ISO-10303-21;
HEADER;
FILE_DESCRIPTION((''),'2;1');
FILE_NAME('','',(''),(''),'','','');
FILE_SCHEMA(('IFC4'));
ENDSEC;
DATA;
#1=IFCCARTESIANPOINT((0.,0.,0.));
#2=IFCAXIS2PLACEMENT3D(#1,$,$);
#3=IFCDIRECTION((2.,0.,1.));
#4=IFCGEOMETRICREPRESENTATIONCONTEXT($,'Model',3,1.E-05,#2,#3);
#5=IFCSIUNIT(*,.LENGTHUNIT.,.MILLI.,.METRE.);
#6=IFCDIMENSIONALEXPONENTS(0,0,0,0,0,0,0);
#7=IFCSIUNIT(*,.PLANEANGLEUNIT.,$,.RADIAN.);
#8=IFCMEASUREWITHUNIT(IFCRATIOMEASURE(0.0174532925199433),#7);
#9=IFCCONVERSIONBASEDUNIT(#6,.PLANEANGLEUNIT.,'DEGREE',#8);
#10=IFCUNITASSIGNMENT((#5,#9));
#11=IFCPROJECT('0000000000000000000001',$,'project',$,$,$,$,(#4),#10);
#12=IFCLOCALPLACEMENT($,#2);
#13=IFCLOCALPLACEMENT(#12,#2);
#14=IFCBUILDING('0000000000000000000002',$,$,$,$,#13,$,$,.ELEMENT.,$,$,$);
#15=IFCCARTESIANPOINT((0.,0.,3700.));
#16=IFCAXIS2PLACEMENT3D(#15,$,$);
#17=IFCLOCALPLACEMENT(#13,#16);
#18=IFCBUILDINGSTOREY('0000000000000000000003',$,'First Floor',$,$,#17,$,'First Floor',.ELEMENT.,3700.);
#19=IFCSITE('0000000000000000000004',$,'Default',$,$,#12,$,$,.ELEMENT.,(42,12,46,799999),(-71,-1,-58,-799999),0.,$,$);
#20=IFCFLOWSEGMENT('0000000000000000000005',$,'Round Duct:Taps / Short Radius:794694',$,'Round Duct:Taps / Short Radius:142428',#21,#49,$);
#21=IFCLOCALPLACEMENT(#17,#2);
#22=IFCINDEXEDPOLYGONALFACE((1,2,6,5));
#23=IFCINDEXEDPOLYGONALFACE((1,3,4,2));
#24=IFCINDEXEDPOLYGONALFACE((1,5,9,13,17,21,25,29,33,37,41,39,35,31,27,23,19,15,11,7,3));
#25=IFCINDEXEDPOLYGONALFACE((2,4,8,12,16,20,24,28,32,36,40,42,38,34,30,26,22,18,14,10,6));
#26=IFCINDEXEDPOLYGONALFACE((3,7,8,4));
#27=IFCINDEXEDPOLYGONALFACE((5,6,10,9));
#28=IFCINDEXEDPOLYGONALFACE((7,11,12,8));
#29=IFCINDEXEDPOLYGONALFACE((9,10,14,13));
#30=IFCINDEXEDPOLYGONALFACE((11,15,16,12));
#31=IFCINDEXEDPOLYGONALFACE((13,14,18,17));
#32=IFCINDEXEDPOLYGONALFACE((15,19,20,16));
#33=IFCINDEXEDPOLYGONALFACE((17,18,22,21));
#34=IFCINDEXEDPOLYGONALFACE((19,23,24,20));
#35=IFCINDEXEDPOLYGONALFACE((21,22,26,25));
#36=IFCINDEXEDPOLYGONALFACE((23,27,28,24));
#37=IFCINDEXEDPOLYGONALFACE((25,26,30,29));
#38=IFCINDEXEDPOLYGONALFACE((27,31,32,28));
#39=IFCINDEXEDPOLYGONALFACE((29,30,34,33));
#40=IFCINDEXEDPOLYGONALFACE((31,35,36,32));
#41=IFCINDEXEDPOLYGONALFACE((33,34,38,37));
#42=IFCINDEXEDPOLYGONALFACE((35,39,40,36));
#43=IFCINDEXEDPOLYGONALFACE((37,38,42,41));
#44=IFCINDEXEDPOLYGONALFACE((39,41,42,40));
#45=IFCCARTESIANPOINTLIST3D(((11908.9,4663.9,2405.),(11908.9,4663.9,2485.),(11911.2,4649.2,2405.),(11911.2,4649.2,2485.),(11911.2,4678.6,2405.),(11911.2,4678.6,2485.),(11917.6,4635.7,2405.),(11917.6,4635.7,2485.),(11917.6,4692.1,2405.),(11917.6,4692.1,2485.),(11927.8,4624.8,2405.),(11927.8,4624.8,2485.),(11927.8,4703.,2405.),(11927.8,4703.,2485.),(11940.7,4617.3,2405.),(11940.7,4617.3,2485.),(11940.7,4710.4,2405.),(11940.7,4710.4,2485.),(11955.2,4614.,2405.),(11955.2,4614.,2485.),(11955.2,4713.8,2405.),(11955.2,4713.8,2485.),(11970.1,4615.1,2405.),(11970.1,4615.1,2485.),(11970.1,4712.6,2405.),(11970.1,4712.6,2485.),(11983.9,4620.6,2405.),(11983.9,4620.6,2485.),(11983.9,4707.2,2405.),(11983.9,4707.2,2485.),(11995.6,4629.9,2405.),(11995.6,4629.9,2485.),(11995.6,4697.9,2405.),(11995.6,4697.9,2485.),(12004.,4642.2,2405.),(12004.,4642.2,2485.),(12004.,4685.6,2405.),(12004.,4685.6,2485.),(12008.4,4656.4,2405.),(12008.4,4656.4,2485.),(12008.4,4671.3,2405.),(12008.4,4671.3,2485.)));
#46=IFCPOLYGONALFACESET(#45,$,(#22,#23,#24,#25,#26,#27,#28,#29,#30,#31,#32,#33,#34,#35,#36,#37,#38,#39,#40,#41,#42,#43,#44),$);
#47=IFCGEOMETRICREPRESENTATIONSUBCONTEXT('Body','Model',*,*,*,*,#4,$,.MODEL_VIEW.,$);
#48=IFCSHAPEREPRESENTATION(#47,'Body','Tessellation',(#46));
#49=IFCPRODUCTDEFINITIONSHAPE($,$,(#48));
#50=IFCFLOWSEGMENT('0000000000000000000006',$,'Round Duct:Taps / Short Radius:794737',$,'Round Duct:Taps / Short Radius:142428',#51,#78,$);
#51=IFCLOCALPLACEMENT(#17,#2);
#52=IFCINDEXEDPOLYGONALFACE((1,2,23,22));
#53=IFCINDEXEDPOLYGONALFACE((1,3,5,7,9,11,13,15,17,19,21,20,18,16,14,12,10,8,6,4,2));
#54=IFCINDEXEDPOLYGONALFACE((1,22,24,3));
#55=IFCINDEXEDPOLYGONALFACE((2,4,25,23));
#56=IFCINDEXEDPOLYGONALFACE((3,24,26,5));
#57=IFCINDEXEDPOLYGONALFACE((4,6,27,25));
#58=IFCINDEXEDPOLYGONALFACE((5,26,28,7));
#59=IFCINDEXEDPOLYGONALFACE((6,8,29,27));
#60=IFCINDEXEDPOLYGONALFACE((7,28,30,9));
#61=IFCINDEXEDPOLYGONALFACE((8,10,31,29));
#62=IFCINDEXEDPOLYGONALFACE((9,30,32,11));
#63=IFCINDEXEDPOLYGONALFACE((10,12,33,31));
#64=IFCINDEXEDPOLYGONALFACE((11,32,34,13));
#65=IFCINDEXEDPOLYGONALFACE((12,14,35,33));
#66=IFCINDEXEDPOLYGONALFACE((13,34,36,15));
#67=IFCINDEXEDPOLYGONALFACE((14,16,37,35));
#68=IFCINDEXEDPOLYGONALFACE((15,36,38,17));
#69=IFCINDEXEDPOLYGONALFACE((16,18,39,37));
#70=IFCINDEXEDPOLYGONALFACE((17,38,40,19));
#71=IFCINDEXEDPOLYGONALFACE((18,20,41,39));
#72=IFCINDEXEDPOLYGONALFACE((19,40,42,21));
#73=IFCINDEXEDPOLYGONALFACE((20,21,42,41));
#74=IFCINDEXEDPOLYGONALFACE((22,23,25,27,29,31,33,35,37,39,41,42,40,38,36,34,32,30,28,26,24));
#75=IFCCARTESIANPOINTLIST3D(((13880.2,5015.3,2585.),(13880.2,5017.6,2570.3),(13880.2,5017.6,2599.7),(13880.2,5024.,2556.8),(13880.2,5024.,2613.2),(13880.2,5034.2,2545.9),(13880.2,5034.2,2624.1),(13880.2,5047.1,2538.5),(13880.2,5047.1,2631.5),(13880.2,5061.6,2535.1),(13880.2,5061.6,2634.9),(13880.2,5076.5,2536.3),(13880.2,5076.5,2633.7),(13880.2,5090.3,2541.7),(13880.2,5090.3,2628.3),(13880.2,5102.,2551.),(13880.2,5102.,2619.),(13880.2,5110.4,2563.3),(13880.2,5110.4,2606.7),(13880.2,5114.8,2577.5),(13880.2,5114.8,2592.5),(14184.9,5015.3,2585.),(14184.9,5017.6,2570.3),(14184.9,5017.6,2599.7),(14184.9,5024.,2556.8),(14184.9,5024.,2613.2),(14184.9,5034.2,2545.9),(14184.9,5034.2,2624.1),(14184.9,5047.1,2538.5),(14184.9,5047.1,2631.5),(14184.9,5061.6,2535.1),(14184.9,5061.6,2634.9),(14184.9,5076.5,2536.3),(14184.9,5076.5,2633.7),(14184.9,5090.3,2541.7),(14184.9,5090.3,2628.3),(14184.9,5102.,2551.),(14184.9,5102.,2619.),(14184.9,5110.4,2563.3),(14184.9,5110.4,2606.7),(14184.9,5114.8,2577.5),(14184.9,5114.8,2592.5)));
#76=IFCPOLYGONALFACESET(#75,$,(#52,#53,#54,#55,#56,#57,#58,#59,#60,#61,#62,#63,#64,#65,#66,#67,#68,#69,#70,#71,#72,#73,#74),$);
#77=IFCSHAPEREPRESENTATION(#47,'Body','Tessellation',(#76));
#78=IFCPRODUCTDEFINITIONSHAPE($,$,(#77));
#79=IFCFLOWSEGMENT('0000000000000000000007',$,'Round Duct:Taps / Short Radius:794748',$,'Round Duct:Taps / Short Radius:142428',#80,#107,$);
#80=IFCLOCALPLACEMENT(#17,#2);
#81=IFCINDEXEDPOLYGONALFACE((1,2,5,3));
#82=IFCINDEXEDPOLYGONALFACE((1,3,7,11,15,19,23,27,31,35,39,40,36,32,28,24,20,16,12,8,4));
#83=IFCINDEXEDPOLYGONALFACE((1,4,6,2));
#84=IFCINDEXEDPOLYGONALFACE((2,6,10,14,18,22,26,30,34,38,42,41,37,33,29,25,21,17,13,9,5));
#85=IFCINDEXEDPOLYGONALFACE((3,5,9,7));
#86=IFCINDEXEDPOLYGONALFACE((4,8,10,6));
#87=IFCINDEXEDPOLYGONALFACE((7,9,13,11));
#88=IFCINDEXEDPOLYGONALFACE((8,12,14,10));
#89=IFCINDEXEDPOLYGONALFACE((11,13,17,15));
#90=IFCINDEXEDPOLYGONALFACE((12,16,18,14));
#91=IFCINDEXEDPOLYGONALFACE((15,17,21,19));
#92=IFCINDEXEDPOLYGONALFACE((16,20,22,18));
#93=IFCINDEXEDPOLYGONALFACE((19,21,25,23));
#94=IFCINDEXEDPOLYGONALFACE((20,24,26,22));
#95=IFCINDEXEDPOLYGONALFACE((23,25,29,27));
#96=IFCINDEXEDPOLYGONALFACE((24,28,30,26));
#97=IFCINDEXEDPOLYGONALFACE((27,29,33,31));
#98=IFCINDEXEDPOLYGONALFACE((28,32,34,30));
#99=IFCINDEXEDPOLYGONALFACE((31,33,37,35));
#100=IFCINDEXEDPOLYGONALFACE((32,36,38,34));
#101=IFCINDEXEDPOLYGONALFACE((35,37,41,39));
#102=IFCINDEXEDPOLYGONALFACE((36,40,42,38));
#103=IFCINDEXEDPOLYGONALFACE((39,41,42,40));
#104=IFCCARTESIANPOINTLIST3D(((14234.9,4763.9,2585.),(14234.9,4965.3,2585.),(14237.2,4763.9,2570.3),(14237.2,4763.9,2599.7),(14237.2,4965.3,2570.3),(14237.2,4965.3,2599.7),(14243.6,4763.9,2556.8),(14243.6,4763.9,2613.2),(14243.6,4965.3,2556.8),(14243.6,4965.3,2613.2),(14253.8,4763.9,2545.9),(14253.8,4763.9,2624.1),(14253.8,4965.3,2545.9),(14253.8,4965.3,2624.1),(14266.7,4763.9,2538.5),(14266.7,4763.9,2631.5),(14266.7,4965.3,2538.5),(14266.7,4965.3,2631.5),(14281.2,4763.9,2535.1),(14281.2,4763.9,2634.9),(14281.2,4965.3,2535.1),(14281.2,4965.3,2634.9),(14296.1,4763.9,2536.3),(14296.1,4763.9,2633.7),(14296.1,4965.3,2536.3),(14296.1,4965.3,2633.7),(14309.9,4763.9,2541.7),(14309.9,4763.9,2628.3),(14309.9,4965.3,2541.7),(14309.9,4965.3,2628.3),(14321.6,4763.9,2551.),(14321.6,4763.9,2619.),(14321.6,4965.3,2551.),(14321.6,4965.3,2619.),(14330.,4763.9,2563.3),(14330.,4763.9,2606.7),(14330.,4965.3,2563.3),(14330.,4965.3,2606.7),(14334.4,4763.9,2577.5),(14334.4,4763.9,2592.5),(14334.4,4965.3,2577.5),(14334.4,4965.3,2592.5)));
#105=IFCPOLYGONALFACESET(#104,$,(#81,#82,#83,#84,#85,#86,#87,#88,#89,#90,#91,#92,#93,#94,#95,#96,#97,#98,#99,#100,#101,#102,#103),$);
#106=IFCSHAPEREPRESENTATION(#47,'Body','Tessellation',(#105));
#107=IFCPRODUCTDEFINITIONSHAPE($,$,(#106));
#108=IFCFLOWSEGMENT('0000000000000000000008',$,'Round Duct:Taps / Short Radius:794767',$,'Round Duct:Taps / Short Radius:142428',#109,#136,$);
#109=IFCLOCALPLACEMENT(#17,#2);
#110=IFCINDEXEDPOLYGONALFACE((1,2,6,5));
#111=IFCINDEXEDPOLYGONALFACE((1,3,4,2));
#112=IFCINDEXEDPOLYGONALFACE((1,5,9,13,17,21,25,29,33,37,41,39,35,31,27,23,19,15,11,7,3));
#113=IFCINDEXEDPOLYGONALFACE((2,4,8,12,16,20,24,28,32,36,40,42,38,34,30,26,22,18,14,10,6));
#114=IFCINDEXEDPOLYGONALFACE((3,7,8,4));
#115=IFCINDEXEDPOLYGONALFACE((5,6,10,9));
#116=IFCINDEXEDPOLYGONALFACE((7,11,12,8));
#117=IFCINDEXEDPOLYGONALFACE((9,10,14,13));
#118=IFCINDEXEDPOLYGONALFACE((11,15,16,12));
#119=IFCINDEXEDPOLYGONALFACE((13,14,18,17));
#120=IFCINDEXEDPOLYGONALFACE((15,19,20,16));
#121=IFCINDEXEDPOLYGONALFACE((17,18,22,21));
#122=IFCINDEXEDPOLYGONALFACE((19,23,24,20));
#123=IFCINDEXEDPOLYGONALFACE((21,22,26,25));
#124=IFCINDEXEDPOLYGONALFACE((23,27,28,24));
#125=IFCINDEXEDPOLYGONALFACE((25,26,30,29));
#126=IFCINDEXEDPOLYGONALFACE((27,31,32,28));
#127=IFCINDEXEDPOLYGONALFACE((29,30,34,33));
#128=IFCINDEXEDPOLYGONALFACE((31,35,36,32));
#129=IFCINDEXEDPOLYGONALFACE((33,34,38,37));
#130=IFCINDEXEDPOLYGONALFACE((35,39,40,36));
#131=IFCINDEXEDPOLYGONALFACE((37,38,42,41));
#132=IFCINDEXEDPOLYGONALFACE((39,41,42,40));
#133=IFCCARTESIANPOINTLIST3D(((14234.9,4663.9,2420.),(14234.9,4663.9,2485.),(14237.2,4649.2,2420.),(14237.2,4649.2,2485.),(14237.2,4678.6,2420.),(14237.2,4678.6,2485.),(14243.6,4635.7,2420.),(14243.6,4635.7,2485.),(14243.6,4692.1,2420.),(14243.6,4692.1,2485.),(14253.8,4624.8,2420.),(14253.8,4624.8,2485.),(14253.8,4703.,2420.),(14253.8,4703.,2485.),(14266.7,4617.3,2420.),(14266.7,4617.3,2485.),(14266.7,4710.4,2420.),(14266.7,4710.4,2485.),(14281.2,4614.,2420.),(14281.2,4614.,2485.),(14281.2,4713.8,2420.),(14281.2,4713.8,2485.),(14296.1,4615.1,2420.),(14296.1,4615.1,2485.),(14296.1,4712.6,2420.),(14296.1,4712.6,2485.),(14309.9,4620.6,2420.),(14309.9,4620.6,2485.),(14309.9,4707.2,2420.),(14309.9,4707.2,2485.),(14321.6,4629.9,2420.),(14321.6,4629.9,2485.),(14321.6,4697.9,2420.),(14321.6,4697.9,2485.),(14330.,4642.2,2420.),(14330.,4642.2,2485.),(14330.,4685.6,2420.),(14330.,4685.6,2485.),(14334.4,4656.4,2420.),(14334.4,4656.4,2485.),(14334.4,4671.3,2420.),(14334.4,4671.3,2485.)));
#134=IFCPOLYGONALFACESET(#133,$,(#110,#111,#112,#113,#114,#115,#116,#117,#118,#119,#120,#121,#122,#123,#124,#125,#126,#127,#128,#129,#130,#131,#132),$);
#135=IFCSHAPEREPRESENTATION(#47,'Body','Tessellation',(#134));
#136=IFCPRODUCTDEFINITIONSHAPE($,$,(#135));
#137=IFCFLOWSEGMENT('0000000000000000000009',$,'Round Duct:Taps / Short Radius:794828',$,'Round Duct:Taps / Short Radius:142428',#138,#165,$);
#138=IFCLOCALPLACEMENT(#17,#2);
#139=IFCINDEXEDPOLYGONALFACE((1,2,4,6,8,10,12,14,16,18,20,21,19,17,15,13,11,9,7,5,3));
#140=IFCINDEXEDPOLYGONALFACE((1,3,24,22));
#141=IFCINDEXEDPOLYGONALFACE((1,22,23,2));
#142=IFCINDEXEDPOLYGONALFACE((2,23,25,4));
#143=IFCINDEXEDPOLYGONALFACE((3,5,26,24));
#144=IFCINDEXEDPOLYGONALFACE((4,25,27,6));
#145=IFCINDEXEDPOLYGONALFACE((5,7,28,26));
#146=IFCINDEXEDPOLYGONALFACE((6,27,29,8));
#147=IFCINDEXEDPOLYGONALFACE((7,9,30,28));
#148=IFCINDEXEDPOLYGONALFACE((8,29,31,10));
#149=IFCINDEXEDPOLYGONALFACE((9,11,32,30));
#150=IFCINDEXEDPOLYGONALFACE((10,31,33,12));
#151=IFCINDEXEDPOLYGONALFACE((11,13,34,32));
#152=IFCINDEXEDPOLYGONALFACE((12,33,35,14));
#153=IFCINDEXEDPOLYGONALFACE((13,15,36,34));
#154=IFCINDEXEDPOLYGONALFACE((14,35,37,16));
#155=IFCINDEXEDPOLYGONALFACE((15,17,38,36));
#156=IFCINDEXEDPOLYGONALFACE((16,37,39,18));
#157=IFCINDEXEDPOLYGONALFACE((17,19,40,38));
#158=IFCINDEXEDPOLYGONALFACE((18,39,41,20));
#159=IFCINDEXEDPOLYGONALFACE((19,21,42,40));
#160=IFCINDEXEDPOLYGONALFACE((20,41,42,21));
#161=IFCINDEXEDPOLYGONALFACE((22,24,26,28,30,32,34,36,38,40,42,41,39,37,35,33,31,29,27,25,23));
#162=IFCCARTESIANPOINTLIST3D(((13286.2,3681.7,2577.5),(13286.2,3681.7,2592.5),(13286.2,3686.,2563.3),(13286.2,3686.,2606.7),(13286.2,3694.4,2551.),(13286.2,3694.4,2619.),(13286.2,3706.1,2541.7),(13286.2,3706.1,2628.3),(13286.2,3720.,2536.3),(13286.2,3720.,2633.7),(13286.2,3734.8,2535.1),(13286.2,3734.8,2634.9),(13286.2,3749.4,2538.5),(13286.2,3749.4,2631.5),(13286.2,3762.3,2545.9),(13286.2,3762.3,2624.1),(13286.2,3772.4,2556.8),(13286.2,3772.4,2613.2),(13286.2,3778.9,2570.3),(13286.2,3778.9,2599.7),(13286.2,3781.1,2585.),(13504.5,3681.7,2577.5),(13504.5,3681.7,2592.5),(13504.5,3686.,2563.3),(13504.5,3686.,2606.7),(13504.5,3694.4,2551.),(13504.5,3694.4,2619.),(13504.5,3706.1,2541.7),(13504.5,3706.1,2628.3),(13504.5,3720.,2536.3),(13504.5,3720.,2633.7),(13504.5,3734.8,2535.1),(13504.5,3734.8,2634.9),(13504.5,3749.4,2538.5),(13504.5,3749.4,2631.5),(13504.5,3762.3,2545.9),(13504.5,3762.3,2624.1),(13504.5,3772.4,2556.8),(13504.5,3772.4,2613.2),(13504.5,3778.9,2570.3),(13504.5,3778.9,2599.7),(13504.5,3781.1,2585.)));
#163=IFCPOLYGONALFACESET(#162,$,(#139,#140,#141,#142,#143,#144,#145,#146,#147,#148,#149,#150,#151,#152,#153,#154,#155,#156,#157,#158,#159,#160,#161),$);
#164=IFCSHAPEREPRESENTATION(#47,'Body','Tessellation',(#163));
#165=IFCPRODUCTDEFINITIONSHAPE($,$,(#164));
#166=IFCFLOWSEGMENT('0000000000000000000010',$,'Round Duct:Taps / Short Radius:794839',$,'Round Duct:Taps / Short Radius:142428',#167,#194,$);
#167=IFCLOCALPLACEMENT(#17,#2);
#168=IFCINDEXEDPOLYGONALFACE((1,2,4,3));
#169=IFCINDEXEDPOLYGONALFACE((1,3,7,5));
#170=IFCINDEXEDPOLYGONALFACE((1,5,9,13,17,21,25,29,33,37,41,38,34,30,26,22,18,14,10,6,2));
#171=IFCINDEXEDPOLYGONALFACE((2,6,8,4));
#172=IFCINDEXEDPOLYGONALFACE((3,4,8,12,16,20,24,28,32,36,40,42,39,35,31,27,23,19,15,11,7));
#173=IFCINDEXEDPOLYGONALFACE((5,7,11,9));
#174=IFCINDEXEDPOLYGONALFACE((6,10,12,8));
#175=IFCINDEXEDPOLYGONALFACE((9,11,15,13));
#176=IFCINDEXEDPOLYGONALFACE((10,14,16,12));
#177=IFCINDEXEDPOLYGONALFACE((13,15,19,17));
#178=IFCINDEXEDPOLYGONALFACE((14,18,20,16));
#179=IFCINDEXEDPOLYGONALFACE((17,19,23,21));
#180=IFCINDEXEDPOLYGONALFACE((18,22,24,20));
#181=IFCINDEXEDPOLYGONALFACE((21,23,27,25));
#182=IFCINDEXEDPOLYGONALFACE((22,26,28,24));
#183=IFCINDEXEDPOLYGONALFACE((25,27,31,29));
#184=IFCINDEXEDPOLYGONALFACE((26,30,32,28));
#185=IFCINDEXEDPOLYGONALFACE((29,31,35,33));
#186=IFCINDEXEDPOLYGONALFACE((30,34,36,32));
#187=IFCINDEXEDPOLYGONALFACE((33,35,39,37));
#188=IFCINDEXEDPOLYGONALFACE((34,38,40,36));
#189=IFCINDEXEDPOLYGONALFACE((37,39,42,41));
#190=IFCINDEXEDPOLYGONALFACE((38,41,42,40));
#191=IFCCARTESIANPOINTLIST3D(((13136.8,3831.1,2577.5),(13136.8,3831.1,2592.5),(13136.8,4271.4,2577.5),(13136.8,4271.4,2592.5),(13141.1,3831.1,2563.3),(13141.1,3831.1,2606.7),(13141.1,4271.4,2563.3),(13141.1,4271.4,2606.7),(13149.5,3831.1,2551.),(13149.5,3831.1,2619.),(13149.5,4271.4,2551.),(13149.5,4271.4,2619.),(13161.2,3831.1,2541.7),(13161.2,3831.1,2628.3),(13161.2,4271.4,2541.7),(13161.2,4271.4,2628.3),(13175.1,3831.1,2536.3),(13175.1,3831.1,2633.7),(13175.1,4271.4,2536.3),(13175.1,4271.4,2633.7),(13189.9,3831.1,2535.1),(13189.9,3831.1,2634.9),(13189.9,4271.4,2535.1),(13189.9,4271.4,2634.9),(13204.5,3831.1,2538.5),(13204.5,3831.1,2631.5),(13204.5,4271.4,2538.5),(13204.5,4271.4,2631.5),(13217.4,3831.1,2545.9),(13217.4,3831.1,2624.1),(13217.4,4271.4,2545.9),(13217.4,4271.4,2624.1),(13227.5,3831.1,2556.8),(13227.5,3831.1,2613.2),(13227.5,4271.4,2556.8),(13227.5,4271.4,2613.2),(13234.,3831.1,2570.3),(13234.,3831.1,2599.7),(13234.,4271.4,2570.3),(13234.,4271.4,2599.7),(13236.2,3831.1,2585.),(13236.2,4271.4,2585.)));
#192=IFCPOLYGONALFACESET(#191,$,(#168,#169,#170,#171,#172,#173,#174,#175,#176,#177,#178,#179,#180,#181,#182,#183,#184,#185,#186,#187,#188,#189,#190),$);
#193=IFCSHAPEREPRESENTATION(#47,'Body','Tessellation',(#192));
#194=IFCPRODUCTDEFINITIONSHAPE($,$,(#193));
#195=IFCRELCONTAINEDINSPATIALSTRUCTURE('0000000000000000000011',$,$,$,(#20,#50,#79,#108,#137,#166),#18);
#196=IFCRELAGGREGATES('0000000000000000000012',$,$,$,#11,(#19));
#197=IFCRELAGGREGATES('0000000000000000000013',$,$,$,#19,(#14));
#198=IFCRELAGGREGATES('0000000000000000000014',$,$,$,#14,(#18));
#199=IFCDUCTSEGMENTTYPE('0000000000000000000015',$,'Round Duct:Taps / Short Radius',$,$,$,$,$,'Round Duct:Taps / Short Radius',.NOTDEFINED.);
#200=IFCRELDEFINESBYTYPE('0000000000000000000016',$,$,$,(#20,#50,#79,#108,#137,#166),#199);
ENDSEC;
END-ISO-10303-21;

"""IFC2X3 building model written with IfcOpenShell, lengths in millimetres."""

from ifc_helpers import new_model, entity, si_unit, converted_unit, direction, frame, frame_2d, origin, origin_2d_with_axis, place, context, subcontext, project, spatial, circle, extrude, type_object, element, save


model = new_model("IFC2X3")

# Units and contexts
model_context = context("Model", 3, precision=1e-05, world=origin(), true_north=direction((2.0, 0.0, 1.0)))
body_context = subcontext(model_context, "Body", "Model", "MODEL_VIEW")
ifc_project = project(units=[si_unit("LENGTHUNIT", "METRE", prefix="MILLI"), converted_unit("PLANEANGLEUNIT", "DEGREE", entity("IfcRatioMeasure", 0.0174532925199433), si_unit("PLANEANGLEUNIT", "RADIAN"), dimensions=[0, 0, 0, 0, 0, 0, 0])], contexts=[model_context])

# Site, building, storey
site_placement = place(None, origin())
site = spatial("IfcSite", under=ifc_project, at=site_placement, Name="Default", CompositionType="ELEMENT", RefLatitude=(42, 12, 46, 799999), RefLongitude=(-71, -1, -58, -799999), RefElevation=0.0)
building_placement = place(site_placement, origin())
building = spatial("IfcBuilding", under=site, at=building_placement, CompositionType="ELEMENT")
storey_placement = place(building_placement, frame((0.0, 0.0, 3700.0)))
storey = spatial("IfcBuildingStorey", under=building, at=storey_placement, Name="First Floor", LongName="First Floor", CompositionType="ELEMENT", Elevation=3700.0)

# Flow segments
duct_segment_type_1 = type_object("IfcDuctSegmentType", Name="Round Duct:Taps / Short Radius", ElementType="Round Duct:Taps / Short Radius", PredefinedType="NOTDEFINED")
flow_segment_1_placement = place(storey_placement, origin())
element("IfcFlowSegment", 1, at=flow_segment_1_placement, inside=storey, type_object=duct_segment_type_1, Name="Round Duct:Taps / Short Radius:794694", ObjectType="Round Duct:Taps / Short Radius:142428", context=body_context, shape_type="SweptSolid", body=[
    extrude(circle(Radius=50.0, at=frame_2d((0.0, 0.0), x_axis=(1.0, 0.0))), frame((11958.9, 4663.9, 2405.0), z_axis=(0.0, 0.0, 1.0), x_axis=(-1.0, 0.0, 0.0)), (0.0, 0.0, 1.0), 80.0),
])
flow_segment_2_placement = place(storey_placement, origin())
element("IfcFlowSegment", 2, at=flow_segment_2_placement, inside=storey, type_object=duct_segment_type_1, Name="Round Duct:Taps / Short Radius:794737", ObjectType="Round Duct:Taps / Short Radius:142428", context=body_context, shape_type="SweptSolid", body=[
    extrude(circle(Radius=50.0, at=origin_2d_with_axis()), frame((13880.2, 5065.3, 2585.0), z_axis=(1.0, 0.0, 0.0), x_axis=(0.0, -1.0, 0.0)), (0.0, 0.0, 1.0), 304.8),
])
flow_segment_3_placement = place(storey_placement, origin())
element("IfcFlowSegment", 3, at=flow_segment_3_placement, inside=storey, type_object=duct_segment_type_1, Name="Round Duct:Taps / Short Radius:794748", ObjectType="Round Duct:Taps / Short Radius:142428", context=body_context, shape_type="SweptSolid", body=[
    extrude(circle(Radius=50.0, at=frame_2d((0.0, 0.0), x_axis=(1.0, 0.0))), frame((14284.9, 4763.9, 2585.0), z_axis=(0.0, 1.0, 0.0), x_axis=(-1.0, 0.0, 0.0)), (0.0, 0.0, 1.0), 201.5),
])
flow_segment_4_placement = place(storey_placement, origin())
element("IfcFlowSegment", 4, at=flow_segment_4_placement, inside=storey, type_object=duct_segment_type_1, Name="Round Duct:Taps / Short Radius:794767", ObjectType="Round Duct:Taps / Short Radius:142428", context=body_context, shape_type="SweptSolid", body=[
    extrude(circle(Radius=50.0, at=frame_2d((0.0, 0.0), x_axis=(1.0, 0.0))), frame((14284.9, 4663.9, 2420.0), z_axis=(0.0, 0.0, 1.0), x_axis=(-1.0, 0.0, 0.0)), (0.0, 0.0, 1.0), 65.0),
])
flow_segment_5_placement = place(storey_placement, origin())
element("IfcFlowSegment", 5, at=flow_segment_5_placement, inside=storey, type_object=duct_segment_type_1, Name="Round Duct:Taps / Short Radius:794828", ObjectType="Round Duct:Taps / Short Radius:142428", context=body_context, shape_type="SweptSolid", body=[
    extrude(circle(Radius=50.0, at=frame_2d((0.0, 0.0), x_axis=(1.0, 0.0))), frame((13286.2, 3731.1, 2585.0), z_axis=(1.0, 0.0, 0.0), x_axis=(0.0, 1.0, 0.0)), (0.0, 0.0, 1.0), 218.3),
])
flow_segment_6_placement = place(storey_placement, origin())
element("IfcFlowSegment", 6, at=flow_segment_6_placement, inside=storey, type_object=duct_segment_type_1, Name="Round Duct:Taps / Short Radius:794839", ObjectType="Round Duct:Taps / Short Radius:142428", context=body_context, shape_type="SweptSolid", body=[
    extrude(circle(Radius=50.0, at=origin_2d_with_axis()), frame((13186.2, 3831.1, 2585.0), z_axis=(0.0, 1.0, 0.0), x_axis=(1.0, 0.0, 0.0)), (0.0, 0.0, 1.0), 440.3),
])

save(model, "model.ifc")
